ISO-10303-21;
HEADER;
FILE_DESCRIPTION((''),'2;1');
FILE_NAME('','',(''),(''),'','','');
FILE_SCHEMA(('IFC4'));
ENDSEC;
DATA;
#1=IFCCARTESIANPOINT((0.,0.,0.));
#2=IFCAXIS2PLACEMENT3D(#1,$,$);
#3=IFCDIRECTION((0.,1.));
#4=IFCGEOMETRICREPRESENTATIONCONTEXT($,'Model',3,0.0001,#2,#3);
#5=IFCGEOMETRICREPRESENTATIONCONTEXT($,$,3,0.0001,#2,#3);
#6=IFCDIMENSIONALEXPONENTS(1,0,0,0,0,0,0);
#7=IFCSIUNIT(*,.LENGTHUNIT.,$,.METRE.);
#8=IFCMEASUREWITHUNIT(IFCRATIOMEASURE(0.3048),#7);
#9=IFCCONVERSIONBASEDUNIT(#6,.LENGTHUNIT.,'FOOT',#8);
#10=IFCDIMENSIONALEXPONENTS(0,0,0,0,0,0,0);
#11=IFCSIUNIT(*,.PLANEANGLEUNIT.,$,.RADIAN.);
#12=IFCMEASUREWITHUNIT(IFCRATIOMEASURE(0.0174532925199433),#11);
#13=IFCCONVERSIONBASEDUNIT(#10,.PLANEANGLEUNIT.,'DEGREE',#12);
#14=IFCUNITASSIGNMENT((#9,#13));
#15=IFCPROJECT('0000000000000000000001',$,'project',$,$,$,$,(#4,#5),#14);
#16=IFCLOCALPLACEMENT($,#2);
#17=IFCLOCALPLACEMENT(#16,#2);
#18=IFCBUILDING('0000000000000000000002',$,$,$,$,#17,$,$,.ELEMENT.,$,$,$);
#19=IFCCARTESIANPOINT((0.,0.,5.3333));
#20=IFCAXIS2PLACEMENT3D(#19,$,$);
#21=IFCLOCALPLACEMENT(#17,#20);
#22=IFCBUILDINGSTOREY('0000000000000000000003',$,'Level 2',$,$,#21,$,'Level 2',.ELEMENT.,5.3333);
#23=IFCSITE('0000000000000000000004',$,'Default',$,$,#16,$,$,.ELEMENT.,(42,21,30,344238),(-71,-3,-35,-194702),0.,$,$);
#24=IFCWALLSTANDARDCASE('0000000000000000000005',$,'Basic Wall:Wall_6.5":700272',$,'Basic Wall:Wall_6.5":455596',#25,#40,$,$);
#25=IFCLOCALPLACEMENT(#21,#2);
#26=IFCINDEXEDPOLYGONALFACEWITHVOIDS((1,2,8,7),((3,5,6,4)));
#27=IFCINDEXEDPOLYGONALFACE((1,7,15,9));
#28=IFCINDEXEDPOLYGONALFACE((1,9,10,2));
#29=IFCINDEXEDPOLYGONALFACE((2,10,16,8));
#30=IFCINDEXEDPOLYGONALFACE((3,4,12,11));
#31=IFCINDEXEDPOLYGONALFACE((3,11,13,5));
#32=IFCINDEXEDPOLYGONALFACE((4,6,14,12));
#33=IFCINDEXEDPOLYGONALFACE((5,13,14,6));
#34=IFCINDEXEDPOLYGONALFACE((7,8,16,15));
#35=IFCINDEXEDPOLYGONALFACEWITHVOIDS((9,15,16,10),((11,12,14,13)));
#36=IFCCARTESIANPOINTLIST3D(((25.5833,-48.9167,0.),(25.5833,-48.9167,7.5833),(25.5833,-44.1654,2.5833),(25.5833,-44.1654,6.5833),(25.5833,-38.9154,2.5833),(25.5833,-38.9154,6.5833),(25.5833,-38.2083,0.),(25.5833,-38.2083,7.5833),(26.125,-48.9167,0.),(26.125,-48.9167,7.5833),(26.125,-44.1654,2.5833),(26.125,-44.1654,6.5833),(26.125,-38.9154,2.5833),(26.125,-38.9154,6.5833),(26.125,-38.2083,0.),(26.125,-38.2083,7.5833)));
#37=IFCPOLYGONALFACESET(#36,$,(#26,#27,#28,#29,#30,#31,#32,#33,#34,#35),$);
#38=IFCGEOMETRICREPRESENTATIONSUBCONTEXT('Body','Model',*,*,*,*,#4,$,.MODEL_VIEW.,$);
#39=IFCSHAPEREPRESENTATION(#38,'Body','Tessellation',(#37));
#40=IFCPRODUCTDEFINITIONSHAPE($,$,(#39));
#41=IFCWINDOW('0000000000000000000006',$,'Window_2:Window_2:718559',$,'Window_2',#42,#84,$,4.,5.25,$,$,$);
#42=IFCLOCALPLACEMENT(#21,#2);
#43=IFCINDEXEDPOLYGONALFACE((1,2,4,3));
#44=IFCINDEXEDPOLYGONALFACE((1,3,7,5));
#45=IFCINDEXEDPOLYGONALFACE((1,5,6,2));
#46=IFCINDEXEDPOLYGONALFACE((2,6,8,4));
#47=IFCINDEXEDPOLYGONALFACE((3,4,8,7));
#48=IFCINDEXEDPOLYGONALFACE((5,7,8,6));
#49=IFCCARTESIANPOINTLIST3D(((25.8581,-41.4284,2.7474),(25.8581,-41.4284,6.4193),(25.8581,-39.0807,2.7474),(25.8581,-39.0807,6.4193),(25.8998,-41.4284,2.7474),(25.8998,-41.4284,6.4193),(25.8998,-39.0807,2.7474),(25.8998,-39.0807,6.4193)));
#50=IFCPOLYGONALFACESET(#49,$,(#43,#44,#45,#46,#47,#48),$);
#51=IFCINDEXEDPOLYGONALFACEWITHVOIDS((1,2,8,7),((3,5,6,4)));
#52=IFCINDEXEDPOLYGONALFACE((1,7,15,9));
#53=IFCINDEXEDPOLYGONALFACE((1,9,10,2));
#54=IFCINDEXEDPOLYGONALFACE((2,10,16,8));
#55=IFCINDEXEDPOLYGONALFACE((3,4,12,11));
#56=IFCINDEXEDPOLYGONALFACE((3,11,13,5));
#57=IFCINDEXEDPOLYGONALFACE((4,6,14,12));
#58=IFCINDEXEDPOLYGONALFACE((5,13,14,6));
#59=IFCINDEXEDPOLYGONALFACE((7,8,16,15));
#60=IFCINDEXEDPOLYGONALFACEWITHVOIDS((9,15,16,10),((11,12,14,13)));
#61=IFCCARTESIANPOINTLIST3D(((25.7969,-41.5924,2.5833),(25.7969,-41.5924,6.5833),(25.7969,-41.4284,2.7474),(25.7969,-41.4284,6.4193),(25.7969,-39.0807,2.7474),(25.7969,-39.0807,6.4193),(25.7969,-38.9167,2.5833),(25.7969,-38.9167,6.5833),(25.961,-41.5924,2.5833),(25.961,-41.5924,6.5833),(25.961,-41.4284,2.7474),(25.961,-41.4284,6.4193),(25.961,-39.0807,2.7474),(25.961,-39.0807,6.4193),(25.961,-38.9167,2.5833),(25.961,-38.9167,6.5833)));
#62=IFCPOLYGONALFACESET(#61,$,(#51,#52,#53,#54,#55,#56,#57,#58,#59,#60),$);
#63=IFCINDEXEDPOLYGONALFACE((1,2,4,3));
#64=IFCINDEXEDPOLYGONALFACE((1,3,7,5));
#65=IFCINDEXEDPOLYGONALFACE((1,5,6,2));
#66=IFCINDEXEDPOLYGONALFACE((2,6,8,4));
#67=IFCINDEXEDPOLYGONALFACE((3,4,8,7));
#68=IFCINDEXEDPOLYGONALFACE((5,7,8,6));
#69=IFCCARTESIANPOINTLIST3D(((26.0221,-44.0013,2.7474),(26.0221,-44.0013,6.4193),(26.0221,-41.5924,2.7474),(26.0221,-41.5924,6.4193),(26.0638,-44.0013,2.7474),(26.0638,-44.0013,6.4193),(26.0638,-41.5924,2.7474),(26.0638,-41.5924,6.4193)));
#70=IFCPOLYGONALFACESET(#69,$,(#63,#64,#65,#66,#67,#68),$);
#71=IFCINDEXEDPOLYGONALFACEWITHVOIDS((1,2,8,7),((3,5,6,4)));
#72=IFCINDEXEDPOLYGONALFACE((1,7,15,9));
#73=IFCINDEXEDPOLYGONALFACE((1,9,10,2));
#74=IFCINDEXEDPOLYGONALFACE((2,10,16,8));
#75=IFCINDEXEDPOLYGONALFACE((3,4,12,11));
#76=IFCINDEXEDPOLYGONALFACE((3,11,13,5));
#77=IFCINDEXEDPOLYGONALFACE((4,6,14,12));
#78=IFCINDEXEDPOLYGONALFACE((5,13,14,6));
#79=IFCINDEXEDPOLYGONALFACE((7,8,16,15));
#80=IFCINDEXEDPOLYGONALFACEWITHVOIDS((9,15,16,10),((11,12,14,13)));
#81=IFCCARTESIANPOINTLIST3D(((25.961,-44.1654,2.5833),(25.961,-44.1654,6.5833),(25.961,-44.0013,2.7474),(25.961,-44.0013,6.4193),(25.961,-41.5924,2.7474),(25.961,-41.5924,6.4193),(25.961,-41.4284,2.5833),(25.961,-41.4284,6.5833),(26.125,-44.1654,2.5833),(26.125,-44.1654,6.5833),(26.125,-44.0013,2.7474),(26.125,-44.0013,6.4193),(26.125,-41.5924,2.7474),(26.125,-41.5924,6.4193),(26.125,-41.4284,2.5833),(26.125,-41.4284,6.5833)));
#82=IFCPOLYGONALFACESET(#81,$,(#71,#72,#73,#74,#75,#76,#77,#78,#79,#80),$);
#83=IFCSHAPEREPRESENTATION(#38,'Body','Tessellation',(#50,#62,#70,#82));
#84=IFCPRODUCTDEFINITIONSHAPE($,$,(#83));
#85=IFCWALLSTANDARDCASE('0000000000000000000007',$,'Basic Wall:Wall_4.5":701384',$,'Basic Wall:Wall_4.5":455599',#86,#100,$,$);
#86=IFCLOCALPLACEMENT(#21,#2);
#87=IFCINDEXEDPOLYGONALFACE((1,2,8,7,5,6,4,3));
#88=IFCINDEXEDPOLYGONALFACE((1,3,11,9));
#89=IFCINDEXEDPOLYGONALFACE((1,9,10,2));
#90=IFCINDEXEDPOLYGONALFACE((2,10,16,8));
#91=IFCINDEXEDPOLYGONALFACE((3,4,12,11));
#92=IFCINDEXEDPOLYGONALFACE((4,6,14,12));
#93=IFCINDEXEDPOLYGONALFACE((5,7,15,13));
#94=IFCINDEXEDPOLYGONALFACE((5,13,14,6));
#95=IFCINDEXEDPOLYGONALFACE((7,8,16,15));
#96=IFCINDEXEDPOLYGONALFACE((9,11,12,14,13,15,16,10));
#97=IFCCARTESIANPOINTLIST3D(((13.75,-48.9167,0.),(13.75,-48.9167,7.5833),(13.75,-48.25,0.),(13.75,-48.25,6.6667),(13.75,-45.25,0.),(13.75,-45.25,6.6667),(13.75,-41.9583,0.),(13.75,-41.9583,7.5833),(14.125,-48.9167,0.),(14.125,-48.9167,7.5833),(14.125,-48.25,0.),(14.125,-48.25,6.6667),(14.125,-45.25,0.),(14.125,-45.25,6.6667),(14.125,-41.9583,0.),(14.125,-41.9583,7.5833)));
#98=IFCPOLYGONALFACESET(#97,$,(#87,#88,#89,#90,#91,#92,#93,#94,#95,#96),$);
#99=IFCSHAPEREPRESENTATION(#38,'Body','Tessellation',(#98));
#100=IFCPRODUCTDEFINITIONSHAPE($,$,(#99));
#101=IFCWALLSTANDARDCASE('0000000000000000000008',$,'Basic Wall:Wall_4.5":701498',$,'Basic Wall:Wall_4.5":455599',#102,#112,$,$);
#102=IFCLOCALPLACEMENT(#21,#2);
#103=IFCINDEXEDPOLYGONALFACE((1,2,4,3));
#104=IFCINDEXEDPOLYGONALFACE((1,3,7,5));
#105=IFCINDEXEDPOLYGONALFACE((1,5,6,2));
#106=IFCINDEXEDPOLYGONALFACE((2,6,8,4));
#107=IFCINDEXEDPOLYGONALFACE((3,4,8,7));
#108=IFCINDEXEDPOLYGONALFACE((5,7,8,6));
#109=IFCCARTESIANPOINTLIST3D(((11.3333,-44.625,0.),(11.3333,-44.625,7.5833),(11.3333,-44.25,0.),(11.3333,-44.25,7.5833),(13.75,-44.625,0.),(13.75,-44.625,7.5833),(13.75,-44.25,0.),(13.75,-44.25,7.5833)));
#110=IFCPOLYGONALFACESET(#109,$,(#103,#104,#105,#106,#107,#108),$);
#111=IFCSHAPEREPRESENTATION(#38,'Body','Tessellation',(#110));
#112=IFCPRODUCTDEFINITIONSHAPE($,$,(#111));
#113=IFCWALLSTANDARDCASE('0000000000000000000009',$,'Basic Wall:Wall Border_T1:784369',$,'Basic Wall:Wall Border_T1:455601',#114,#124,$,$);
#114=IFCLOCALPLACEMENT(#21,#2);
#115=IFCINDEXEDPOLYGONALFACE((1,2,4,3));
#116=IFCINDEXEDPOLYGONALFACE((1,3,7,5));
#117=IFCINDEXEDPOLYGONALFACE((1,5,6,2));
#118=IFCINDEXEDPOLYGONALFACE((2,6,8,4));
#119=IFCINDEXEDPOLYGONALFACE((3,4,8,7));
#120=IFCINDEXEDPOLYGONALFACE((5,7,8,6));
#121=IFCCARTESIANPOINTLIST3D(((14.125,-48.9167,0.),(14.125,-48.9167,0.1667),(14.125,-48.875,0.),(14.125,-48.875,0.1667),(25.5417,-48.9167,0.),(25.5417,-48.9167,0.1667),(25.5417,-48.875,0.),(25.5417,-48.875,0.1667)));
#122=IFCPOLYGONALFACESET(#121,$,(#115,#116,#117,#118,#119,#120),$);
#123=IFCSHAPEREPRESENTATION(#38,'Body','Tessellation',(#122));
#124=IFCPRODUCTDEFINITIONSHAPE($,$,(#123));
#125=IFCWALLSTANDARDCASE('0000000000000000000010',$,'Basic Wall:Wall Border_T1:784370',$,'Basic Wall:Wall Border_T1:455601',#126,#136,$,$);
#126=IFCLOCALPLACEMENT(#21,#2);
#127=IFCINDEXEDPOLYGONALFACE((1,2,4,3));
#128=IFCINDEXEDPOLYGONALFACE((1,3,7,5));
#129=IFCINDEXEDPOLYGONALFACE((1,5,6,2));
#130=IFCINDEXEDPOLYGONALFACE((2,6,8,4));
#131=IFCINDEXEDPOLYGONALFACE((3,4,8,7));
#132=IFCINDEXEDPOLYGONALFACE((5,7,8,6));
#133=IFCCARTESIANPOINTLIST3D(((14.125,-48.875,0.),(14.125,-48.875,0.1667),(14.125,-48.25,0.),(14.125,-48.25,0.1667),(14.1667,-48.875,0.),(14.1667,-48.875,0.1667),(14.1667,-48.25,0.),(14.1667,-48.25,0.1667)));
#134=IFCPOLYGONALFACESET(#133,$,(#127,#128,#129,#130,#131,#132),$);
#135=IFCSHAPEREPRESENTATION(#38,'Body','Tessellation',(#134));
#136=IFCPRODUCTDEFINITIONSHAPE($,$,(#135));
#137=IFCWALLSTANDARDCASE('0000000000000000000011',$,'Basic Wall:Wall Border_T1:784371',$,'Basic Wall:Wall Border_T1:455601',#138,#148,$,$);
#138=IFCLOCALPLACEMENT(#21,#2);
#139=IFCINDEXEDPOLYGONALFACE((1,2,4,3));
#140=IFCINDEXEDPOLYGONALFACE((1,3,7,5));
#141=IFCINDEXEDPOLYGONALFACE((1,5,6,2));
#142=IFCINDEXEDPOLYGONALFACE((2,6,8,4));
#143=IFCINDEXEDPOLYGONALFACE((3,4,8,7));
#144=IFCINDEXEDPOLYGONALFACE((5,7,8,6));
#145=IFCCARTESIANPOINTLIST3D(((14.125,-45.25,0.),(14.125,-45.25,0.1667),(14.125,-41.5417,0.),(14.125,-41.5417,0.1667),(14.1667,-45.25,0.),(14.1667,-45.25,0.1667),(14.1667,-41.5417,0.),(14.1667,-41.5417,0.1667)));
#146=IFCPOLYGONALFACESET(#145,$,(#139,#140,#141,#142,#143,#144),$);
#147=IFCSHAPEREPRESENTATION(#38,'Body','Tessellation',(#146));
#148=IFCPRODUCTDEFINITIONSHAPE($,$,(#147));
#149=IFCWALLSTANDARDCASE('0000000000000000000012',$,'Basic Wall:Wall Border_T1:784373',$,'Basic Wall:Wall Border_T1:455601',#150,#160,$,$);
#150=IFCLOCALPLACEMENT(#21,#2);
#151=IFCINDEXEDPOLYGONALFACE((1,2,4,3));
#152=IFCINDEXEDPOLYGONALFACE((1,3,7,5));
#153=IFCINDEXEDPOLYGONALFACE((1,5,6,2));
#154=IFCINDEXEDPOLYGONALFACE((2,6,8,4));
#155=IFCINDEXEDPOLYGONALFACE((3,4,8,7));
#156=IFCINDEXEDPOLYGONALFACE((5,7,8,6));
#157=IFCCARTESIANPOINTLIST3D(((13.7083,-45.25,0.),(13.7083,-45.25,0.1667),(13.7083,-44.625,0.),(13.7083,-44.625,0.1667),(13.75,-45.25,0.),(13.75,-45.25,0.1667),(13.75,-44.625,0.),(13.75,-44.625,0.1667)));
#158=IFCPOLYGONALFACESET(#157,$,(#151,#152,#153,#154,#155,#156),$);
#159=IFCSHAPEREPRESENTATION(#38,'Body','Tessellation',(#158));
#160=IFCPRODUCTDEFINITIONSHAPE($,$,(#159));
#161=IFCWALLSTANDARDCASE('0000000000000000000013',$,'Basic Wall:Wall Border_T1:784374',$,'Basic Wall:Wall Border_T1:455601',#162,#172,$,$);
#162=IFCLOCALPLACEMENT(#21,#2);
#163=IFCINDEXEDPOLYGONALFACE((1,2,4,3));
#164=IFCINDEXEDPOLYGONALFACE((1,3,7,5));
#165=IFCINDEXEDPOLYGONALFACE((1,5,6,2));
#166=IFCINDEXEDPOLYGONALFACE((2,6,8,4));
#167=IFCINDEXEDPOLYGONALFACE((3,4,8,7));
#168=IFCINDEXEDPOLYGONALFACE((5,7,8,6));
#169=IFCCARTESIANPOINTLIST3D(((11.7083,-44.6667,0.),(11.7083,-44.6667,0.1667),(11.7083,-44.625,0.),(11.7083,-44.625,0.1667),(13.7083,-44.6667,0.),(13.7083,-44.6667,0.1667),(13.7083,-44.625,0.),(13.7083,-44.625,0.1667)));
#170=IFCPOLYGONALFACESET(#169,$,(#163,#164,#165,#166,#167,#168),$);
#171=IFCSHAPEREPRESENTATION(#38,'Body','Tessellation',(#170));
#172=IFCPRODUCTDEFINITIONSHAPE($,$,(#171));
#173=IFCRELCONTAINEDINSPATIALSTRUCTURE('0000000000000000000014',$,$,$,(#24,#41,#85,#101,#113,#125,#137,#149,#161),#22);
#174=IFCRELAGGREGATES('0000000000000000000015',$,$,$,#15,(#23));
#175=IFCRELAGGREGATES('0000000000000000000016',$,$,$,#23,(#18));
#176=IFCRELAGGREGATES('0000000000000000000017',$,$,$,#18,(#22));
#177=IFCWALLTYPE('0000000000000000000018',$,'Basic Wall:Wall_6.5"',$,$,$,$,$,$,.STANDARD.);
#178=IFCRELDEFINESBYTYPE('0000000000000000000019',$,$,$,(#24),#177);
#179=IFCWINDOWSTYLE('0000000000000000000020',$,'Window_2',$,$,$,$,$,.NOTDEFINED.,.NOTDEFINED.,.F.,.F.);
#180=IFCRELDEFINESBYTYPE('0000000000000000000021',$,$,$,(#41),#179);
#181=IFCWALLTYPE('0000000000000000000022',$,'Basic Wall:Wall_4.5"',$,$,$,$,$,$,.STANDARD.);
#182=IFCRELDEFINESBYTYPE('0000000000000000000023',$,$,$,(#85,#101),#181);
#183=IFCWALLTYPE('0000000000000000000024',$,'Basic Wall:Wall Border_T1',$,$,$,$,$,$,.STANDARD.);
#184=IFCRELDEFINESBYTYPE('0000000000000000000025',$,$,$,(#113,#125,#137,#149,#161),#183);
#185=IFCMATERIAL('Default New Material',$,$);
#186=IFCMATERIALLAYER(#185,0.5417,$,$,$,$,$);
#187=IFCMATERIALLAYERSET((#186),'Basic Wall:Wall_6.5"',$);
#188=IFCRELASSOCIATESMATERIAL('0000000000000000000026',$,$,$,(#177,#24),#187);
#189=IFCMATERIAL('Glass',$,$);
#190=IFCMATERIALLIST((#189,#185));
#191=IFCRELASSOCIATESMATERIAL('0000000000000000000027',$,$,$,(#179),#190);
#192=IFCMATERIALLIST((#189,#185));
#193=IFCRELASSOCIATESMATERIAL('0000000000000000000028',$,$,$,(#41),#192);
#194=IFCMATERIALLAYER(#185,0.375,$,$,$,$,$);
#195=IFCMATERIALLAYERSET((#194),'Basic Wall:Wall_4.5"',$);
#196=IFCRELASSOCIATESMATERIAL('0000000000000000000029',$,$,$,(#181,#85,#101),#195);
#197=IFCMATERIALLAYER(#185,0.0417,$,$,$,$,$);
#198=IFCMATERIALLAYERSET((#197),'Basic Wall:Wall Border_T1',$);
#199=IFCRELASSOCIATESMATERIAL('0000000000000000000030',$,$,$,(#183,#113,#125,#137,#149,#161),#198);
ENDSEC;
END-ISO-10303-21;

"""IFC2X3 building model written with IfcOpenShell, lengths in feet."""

from ifc_helpers import new_model, entity, si_unit, converted_unit, direction, frame, frame_2d, origin, origin_2d_with_axis, place, context, subcontext, project, spatial, polyline, rectangle, outline, extrude, source, transform, mapped, material, material_list, layer, layer_set, layer_usage, type_object, type_shapes, element, fill, save


model = new_model("IFC2X3")

# Units and contexts
model_context = context("Model", 3, precision=0.0001, world=origin(), true_north=direction((0.0, 1.0)))
context_of_model = context(None, 3, precision=0.0001, world=origin(), true_north=direction((0.0, 1.0)))
body_context = subcontext(model_context, "Body", "Model", "MODEL_VIEW")
ifc_project = project(units=[converted_unit("LENGTHUNIT", "FOOT", entity("IfcRatioMeasure", 0.3048), si_unit("LENGTHUNIT", "METRE"), dimensions=[1, 0, 0, 0, 0, 0, 0]), converted_unit("PLANEANGLEUNIT", "DEGREE", entity("IfcRatioMeasure", 0.0174532925199433), si_unit("PLANEANGLEUNIT", "RADIAN"), dimensions=[0, 0, 0, 0, 0, 0, 0])], contexts=[model_context, context_of_model])

# Site, building, storey
site_placement = place(None, origin())
site = spatial("IfcSite", under=ifc_project, at=site_placement, Name="Default", CompositionType="ELEMENT", RefLatitude=(42, 21, 30, 344238), RefLongitude=(-71, -3, -35, -194702), RefElevation=0.0)
building_placement = place(site_placement, origin())
building = spatial("IfcBuilding", under=site, at=building_placement, CompositionType="ELEMENT")
storey_placement = place(building_placement, frame((0.0, 0.0, 5.3333)))
storey = spatial("IfcBuildingStorey", under=building, at=storey_placement, Name="Level 2", LongName="Level 2", CompositionType="ELEMENT", Elevation=5.3333)

# Wall, opening, window
ifc_material_1 = material(Name="Default New Material")
ifc_layer_1 = layer(ifc_material_1, 0.5417)
ifc_layer_set_1 = layer_set([ifc_layer_1], Name="Basic Wall:Wall_6.5\"")
ifc_layer_usage_1 = layer_usage(ifc_layer_set_1, "AXIS2", "NEGATIVE", 0.2708)
wall_type_1 = type_object("IfcWallType", Name="Basic Wall:Wall_6.5\"", PredefinedType="STANDARD", material=ifc_layer_set_1)
wall_1_placement = place(storey_placement, frame((25.8542, -48.9167, 0.0), z_axis=(0.0, 0.0, 1.0), x_axis=(0.0, 1.0, 0.0)))
wall_1 = element("IfcWallStandardCase", 1, at=wall_1_placement, inside=storey, type_object=wall_type_1, material=ifc_layer_usage_1, Name="Basic Wall:Wall_6.5\":700272", ObjectType="Basic Wall:Wall_6.5\":455596", context=body_context, shape_type="SweptSolid", body=[
    extrude(rectangle(XDim=10.7083, YDim=0.5417, at=frame_2d((5.3542, 0.0), x_axis=(-1.0, 0.0))), origin(), (0.0, 0.0, 1.0), 7.5833),
])
opening_1_placement = place(wall_1_placement, frame((10.0013, 0.2708, 2.5833)))
opening_1 = element("IfcOpeningElement", 2, at=opening_1_placement, cuts=wall_1, ObjectType="Opening", context=body_context, shape_type="SweptSolid", body=[
    extrude(rectangle(XDim=4.0, YDim=5.25, at=frame_2d((2.0, 2.625), x_axis=(-1.0, 0.0))), frame((0.0, 0.0, 0.0), z_axis=(0.0, -1.0, 0.0), x_axis=(0.0, 0.0, 1.0)), (0.0, 0.0, 1.0), 0.5417),
])
ifc_material_2 = material(Name="Glass")
ifc_material_list_1 = material_list([ifc_material_2, ifc_material_1])
ifc_material_list_2 = material_list([ifc_material_2, ifc_material_1])
window_style = type_object("IfcWindowStyle", Name="Window_2", ConstructionType="NOTDEFINED", OperationType="NOTDEFINED", ParameterTakesPrecedence=False, Sizeable=False, material=ifc_material_list_2)
shared_shape_1 = source(origin(), body_context, "Body", "SweptSolid", [
    extrude(rectangle(XDim=0.0417, YDim=2.3477, at=origin_2d_with_axis()), frame((1.3392, 0.2956, 0.164), z_axis=(0.0, 0.0, 1.0), x_axis=(0.0, -1.0, 0.0)), (0.0, 0.0, 1.0), 3.6719),
    extrude(outline(polyline([(-1.3379, -2.0), (1.3379, -2.0), (1.3379, 2.0), (-1.3379, 2.0), (-1.3379, -2.0)]), holes=[polyline([(-1.1738, -1.836), (-1.1738, 1.836), (1.1738, 1.836), (1.1738, -1.836), (-1.1738, -1.836)])]), frame((1.3392, 0.2136, 2.0), z_axis=(0.0, 1.0, 0.0), x_axis=(1.0, 0.0, 0.0)), (0.0, 0.0, 1.0), 0.164),
    extrude(rectangle(XDim=0.0417, YDim=2.4089, at=frame_2d((0.0, 0.0), x_axis=(1.0, 0.0))), frame((3.8815, 0.4596, 0.164), z_axis=(0.0, 0.0, 1.0), x_axis=(0.0, 1.0, 0.0)), (0.0, 0.0, 1.0), 3.6719),
    extrude(outline(polyline([(-1.3685, -2.0), (1.3685, -2.0), (1.3685, 2.0), (-1.3685, 2.0), (-1.3685, -2.0)]), holes=[polyline([(-1.2044, -1.836), (-1.2044, 1.836), (1.2044, 1.836), (1.2044, -1.836), (-1.2044, -1.836)])]), frame((3.8815, 0.3776, 2.0), z_axis=(0.0, 1.0, 0.0), x_axis=(1.0, 0.0, 0.0)), (0.0, 0.0, 1.0), 0.164),
])
type_shapes(window_style, [shared_shape_1])
window_placement = place(opening_1_placement, frame((0.0, 0.0, 0.0), z_axis=(0.0, 0.0, 1.0), x_axis=(-1.0, 0.0, 0.0)))
window = element("IfcWindow", 3, at=window_placement, inside=storey, type_object=window_style, material=ifc_material_list_1, Name="Window_2:Window_2:718559", ObjectType="Window_2", OverallHeight=4.0, OverallWidth=5.25, context=body_context, shape_type="MappedRepresentation", body=[
    mapped(shared_shape_1, transform((0.0, 0.0, 0.0), scale=1.0)),
])
fill(opening_1, window)

# Shared definitions
ifc_layer_2 = layer(ifc_material_1, 0.375)
ifc_layer_set_2 = layer_set([ifc_layer_2], Name="Basic Wall:Wall_4.5\"")
wall_type_2 = type_object("IfcWallType", Name="Basic Wall:Wall_4.5\"", PredefinedType="STANDARD", material=ifc_layer_set_2)

# Wall, opening
ifc_layer_usage_2 = layer_usage(ifc_layer_set_2, "AXIS2", "NEGATIVE", 0.1875)
wall_2_placement = place(storey_placement, frame((13.9375, -41.9583, 0.0), z_axis=(0.0, 0.0, 1.0), x_axis=(0.0, -1.0, 0.0)))
wall_2 = element("IfcWallStandardCase", 4, at=wall_2_placement, inside=storey, type_object=wall_type_2, material=ifc_layer_usage_2, Name="Basic Wall:Wall_4.5\":701384", ObjectType="Basic Wall:Wall_4.5\":455599", context=body_context, shape_type="SweptSolid", body=[
    extrude(rectangle(XDim=6.9583, YDim=0.375, at=frame_2d((3.4792, 0.0), x_axis=(-1.0, 0.0))), origin(), (0.0, 0.0, 1.0), 7.5833),
])
opening_2_placement = place(wall_2_placement, frame((6.2917, -5.1875, 0.0), z_axis=(0.0, 0.0, 1.0), x_axis=(0.0, 1.0, 0.0)))
element("IfcOpeningElement", 5, at=opening_2_placement, cuts=wall_2, ObjectType="Opening", context=body_context, shape_type="SweptSolid", body=[
    extrude(rectangle(XDim=6.6667, YDim=3.0, at=frame_2d((0.0, 0.0), x_axis=(1.0, 0.0))), frame((0.0, 1.5, 3.3333), z_axis=(1.0, 0.0, 0.0), x_axis=(0.0, 0.0, 1.0)), (0.0, 0.0, 1.0), 10.0),
])

# Walls
ifc_layer_usage_3 = layer_usage(ifc_layer_set_2, "AXIS2", "NEGATIVE", 0.1875)
wall_3_placement = place(storey_placement, frame((13.75, -44.4375, 0.0), z_axis=(0.0, 0.0, 1.0), x_axis=(-1.0, 0.0, 0.0)))
element("IfcWallStandardCase", 6, at=wall_3_placement, inside=storey, type_object=wall_type_2, material=ifc_layer_usage_3, Name="Basic Wall:Wall_4.5\":701498", ObjectType="Basic Wall:Wall_4.5\":455599", context=body_context, shape_type="SweptSolid", body=[
    extrude(rectangle(XDim=2.4167, YDim=0.375, at=frame_2d((1.2083, 0.0), x_axis=(-1.0, 0.0))), origin(), (0.0, 0.0, 1.0), 7.5833),
])
ifc_layer_3 = layer(ifc_material_1, 0.0417)
ifc_layer_set_3 = layer_set([ifc_layer_3], Name="Basic Wall:Wall Border_T1")
ifc_layer_usage_4 = layer_usage(ifc_layer_set_3, "AXIS2", "POSITIVE", -0.0208)
wall_type_3 = type_object("IfcWallType", Name="Basic Wall:Wall Border_T1", PredefinedType="STANDARD", material=ifc_layer_set_3)
wall_4_placement = place(storey_placement, frame((25.5417, -48.8958, 0.0), z_axis=(0.0, 0.0, 1.0), x_axis=(-1.0, 0.0, 0.0)))
element("IfcWallStandardCase", 7, at=wall_4_placement, inside=storey, type_object=wall_type_3, material=ifc_layer_usage_4, Name="Basic Wall:Wall Border_T1:784369", ObjectType="Basic Wall:Wall Border_T1:455601", context=body_context, shape_type="SweptSolid", body=[
    extrude(rectangle(XDim=11.4167, YDim=0.0417, at=frame_2d((5.7083, 0.0), x_axis=(-1.0, 0.0))), origin(), (0.0, 0.0, 1.0), 0.1667),
])
ifc_layer_usage_5 = layer_usage(ifc_layer_set_3, "AXIS2", "POSITIVE", -0.0208)
wall_5_placement = place(storey_placement, frame((14.1458, -48.875, 0.0), z_axis=(0.0, 0.0, 1.0), x_axis=(0.0, 1.0, 0.0)))
element("IfcWallStandardCase", 8, at=wall_5_placement, inside=storey, type_object=wall_type_3, material=ifc_layer_usage_5, Name="Basic Wall:Wall Border_T1:784370", ObjectType="Basic Wall:Wall Border_T1:455601", context=body_context, shape_type="SweptSolid", body=[
    extrude(rectangle(XDim=0.625, YDim=0.0417, at=frame_2d((0.3125, 0.0), x_axis=(-1.0, 0.0))), origin(), (0.0, 0.0, 1.0), 0.1667),
])
ifc_layer_usage_6 = layer_usage(ifc_layer_set_3, "AXIS2", "POSITIVE", -0.0208)
wall_6_placement = place(storey_placement, frame((14.1458, -45.25, 0.0), z_axis=(0.0, 0.0, 1.0), x_axis=(0.0, 1.0, 0.0)))
element("IfcWallStandardCase", 9, at=wall_6_placement, inside=storey, type_object=wall_type_3, material=ifc_layer_usage_6, Name="Basic Wall:Wall Border_T1:784371", ObjectType="Basic Wall:Wall Border_T1:455601", context=body_context, shape_type="SweptSolid", body=[
    extrude(rectangle(XDim=3.7083, YDim=0.0417, at=frame_2d((1.8542, 0.0), x_axis=(-1.0, 0.0))), origin(), (0.0, 0.0, 1.0), 0.1667),
])
ifc_layer_usage_7 = layer_usage(ifc_layer_set_3, "AXIS2", "NEGATIVE", 0.0208)
wall_7_placement = place(storey_placement, frame((13.7292, -45.25, 0.0), z_axis=(0.0, 0.0, 1.0), x_axis=(0.0, 1.0, 0.0)))
element("IfcWallStandardCase", 10, at=wall_7_placement, inside=storey, type_object=wall_type_3, material=ifc_layer_usage_7, Name="Basic Wall:Wall Border_T1:784373", ObjectType="Basic Wall:Wall Border_T1:455601", context=body_context, shape_type="SweptSolid", body=[
    extrude(rectangle(XDim=0.625, YDim=0.0417, at=frame_2d((0.3125, 0.0), x_axis=(-1.0, 0.0))), origin(), (0.0, 0.0, 1.0), 0.1667),
])
ifc_layer_usage_8 = layer_usage(ifc_layer_set_3, "AXIS2", "NEGATIVE", 0.0208)
wall_8_placement = place(storey_placement, frame((13.7083, -44.6458, 0.0), z_axis=(0.0, 0.0, 1.0), x_axis=(-1.0, 0.0, 0.0)))
element("IfcWallStandardCase", 11, at=wall_8_placement, inside=storey, type_object=wall_type_3, material=ifc_layer_usage_8, Name="Basic Wall:Wall Border_T1:784374", ObjectType="Basic Wall:Wall Border_T1:455601", context=body_context, shape_type="SweptSolid", body=[
    extrude(rectangle(XDim=2.0, YDim=0.0417, at=frame_2d((1.0, 0.0), x_axis=(-1.0, 0.0))), origin(), (0.0, 0.0, 1.0), 0.1667),
])

save(model, "model.ifc")
